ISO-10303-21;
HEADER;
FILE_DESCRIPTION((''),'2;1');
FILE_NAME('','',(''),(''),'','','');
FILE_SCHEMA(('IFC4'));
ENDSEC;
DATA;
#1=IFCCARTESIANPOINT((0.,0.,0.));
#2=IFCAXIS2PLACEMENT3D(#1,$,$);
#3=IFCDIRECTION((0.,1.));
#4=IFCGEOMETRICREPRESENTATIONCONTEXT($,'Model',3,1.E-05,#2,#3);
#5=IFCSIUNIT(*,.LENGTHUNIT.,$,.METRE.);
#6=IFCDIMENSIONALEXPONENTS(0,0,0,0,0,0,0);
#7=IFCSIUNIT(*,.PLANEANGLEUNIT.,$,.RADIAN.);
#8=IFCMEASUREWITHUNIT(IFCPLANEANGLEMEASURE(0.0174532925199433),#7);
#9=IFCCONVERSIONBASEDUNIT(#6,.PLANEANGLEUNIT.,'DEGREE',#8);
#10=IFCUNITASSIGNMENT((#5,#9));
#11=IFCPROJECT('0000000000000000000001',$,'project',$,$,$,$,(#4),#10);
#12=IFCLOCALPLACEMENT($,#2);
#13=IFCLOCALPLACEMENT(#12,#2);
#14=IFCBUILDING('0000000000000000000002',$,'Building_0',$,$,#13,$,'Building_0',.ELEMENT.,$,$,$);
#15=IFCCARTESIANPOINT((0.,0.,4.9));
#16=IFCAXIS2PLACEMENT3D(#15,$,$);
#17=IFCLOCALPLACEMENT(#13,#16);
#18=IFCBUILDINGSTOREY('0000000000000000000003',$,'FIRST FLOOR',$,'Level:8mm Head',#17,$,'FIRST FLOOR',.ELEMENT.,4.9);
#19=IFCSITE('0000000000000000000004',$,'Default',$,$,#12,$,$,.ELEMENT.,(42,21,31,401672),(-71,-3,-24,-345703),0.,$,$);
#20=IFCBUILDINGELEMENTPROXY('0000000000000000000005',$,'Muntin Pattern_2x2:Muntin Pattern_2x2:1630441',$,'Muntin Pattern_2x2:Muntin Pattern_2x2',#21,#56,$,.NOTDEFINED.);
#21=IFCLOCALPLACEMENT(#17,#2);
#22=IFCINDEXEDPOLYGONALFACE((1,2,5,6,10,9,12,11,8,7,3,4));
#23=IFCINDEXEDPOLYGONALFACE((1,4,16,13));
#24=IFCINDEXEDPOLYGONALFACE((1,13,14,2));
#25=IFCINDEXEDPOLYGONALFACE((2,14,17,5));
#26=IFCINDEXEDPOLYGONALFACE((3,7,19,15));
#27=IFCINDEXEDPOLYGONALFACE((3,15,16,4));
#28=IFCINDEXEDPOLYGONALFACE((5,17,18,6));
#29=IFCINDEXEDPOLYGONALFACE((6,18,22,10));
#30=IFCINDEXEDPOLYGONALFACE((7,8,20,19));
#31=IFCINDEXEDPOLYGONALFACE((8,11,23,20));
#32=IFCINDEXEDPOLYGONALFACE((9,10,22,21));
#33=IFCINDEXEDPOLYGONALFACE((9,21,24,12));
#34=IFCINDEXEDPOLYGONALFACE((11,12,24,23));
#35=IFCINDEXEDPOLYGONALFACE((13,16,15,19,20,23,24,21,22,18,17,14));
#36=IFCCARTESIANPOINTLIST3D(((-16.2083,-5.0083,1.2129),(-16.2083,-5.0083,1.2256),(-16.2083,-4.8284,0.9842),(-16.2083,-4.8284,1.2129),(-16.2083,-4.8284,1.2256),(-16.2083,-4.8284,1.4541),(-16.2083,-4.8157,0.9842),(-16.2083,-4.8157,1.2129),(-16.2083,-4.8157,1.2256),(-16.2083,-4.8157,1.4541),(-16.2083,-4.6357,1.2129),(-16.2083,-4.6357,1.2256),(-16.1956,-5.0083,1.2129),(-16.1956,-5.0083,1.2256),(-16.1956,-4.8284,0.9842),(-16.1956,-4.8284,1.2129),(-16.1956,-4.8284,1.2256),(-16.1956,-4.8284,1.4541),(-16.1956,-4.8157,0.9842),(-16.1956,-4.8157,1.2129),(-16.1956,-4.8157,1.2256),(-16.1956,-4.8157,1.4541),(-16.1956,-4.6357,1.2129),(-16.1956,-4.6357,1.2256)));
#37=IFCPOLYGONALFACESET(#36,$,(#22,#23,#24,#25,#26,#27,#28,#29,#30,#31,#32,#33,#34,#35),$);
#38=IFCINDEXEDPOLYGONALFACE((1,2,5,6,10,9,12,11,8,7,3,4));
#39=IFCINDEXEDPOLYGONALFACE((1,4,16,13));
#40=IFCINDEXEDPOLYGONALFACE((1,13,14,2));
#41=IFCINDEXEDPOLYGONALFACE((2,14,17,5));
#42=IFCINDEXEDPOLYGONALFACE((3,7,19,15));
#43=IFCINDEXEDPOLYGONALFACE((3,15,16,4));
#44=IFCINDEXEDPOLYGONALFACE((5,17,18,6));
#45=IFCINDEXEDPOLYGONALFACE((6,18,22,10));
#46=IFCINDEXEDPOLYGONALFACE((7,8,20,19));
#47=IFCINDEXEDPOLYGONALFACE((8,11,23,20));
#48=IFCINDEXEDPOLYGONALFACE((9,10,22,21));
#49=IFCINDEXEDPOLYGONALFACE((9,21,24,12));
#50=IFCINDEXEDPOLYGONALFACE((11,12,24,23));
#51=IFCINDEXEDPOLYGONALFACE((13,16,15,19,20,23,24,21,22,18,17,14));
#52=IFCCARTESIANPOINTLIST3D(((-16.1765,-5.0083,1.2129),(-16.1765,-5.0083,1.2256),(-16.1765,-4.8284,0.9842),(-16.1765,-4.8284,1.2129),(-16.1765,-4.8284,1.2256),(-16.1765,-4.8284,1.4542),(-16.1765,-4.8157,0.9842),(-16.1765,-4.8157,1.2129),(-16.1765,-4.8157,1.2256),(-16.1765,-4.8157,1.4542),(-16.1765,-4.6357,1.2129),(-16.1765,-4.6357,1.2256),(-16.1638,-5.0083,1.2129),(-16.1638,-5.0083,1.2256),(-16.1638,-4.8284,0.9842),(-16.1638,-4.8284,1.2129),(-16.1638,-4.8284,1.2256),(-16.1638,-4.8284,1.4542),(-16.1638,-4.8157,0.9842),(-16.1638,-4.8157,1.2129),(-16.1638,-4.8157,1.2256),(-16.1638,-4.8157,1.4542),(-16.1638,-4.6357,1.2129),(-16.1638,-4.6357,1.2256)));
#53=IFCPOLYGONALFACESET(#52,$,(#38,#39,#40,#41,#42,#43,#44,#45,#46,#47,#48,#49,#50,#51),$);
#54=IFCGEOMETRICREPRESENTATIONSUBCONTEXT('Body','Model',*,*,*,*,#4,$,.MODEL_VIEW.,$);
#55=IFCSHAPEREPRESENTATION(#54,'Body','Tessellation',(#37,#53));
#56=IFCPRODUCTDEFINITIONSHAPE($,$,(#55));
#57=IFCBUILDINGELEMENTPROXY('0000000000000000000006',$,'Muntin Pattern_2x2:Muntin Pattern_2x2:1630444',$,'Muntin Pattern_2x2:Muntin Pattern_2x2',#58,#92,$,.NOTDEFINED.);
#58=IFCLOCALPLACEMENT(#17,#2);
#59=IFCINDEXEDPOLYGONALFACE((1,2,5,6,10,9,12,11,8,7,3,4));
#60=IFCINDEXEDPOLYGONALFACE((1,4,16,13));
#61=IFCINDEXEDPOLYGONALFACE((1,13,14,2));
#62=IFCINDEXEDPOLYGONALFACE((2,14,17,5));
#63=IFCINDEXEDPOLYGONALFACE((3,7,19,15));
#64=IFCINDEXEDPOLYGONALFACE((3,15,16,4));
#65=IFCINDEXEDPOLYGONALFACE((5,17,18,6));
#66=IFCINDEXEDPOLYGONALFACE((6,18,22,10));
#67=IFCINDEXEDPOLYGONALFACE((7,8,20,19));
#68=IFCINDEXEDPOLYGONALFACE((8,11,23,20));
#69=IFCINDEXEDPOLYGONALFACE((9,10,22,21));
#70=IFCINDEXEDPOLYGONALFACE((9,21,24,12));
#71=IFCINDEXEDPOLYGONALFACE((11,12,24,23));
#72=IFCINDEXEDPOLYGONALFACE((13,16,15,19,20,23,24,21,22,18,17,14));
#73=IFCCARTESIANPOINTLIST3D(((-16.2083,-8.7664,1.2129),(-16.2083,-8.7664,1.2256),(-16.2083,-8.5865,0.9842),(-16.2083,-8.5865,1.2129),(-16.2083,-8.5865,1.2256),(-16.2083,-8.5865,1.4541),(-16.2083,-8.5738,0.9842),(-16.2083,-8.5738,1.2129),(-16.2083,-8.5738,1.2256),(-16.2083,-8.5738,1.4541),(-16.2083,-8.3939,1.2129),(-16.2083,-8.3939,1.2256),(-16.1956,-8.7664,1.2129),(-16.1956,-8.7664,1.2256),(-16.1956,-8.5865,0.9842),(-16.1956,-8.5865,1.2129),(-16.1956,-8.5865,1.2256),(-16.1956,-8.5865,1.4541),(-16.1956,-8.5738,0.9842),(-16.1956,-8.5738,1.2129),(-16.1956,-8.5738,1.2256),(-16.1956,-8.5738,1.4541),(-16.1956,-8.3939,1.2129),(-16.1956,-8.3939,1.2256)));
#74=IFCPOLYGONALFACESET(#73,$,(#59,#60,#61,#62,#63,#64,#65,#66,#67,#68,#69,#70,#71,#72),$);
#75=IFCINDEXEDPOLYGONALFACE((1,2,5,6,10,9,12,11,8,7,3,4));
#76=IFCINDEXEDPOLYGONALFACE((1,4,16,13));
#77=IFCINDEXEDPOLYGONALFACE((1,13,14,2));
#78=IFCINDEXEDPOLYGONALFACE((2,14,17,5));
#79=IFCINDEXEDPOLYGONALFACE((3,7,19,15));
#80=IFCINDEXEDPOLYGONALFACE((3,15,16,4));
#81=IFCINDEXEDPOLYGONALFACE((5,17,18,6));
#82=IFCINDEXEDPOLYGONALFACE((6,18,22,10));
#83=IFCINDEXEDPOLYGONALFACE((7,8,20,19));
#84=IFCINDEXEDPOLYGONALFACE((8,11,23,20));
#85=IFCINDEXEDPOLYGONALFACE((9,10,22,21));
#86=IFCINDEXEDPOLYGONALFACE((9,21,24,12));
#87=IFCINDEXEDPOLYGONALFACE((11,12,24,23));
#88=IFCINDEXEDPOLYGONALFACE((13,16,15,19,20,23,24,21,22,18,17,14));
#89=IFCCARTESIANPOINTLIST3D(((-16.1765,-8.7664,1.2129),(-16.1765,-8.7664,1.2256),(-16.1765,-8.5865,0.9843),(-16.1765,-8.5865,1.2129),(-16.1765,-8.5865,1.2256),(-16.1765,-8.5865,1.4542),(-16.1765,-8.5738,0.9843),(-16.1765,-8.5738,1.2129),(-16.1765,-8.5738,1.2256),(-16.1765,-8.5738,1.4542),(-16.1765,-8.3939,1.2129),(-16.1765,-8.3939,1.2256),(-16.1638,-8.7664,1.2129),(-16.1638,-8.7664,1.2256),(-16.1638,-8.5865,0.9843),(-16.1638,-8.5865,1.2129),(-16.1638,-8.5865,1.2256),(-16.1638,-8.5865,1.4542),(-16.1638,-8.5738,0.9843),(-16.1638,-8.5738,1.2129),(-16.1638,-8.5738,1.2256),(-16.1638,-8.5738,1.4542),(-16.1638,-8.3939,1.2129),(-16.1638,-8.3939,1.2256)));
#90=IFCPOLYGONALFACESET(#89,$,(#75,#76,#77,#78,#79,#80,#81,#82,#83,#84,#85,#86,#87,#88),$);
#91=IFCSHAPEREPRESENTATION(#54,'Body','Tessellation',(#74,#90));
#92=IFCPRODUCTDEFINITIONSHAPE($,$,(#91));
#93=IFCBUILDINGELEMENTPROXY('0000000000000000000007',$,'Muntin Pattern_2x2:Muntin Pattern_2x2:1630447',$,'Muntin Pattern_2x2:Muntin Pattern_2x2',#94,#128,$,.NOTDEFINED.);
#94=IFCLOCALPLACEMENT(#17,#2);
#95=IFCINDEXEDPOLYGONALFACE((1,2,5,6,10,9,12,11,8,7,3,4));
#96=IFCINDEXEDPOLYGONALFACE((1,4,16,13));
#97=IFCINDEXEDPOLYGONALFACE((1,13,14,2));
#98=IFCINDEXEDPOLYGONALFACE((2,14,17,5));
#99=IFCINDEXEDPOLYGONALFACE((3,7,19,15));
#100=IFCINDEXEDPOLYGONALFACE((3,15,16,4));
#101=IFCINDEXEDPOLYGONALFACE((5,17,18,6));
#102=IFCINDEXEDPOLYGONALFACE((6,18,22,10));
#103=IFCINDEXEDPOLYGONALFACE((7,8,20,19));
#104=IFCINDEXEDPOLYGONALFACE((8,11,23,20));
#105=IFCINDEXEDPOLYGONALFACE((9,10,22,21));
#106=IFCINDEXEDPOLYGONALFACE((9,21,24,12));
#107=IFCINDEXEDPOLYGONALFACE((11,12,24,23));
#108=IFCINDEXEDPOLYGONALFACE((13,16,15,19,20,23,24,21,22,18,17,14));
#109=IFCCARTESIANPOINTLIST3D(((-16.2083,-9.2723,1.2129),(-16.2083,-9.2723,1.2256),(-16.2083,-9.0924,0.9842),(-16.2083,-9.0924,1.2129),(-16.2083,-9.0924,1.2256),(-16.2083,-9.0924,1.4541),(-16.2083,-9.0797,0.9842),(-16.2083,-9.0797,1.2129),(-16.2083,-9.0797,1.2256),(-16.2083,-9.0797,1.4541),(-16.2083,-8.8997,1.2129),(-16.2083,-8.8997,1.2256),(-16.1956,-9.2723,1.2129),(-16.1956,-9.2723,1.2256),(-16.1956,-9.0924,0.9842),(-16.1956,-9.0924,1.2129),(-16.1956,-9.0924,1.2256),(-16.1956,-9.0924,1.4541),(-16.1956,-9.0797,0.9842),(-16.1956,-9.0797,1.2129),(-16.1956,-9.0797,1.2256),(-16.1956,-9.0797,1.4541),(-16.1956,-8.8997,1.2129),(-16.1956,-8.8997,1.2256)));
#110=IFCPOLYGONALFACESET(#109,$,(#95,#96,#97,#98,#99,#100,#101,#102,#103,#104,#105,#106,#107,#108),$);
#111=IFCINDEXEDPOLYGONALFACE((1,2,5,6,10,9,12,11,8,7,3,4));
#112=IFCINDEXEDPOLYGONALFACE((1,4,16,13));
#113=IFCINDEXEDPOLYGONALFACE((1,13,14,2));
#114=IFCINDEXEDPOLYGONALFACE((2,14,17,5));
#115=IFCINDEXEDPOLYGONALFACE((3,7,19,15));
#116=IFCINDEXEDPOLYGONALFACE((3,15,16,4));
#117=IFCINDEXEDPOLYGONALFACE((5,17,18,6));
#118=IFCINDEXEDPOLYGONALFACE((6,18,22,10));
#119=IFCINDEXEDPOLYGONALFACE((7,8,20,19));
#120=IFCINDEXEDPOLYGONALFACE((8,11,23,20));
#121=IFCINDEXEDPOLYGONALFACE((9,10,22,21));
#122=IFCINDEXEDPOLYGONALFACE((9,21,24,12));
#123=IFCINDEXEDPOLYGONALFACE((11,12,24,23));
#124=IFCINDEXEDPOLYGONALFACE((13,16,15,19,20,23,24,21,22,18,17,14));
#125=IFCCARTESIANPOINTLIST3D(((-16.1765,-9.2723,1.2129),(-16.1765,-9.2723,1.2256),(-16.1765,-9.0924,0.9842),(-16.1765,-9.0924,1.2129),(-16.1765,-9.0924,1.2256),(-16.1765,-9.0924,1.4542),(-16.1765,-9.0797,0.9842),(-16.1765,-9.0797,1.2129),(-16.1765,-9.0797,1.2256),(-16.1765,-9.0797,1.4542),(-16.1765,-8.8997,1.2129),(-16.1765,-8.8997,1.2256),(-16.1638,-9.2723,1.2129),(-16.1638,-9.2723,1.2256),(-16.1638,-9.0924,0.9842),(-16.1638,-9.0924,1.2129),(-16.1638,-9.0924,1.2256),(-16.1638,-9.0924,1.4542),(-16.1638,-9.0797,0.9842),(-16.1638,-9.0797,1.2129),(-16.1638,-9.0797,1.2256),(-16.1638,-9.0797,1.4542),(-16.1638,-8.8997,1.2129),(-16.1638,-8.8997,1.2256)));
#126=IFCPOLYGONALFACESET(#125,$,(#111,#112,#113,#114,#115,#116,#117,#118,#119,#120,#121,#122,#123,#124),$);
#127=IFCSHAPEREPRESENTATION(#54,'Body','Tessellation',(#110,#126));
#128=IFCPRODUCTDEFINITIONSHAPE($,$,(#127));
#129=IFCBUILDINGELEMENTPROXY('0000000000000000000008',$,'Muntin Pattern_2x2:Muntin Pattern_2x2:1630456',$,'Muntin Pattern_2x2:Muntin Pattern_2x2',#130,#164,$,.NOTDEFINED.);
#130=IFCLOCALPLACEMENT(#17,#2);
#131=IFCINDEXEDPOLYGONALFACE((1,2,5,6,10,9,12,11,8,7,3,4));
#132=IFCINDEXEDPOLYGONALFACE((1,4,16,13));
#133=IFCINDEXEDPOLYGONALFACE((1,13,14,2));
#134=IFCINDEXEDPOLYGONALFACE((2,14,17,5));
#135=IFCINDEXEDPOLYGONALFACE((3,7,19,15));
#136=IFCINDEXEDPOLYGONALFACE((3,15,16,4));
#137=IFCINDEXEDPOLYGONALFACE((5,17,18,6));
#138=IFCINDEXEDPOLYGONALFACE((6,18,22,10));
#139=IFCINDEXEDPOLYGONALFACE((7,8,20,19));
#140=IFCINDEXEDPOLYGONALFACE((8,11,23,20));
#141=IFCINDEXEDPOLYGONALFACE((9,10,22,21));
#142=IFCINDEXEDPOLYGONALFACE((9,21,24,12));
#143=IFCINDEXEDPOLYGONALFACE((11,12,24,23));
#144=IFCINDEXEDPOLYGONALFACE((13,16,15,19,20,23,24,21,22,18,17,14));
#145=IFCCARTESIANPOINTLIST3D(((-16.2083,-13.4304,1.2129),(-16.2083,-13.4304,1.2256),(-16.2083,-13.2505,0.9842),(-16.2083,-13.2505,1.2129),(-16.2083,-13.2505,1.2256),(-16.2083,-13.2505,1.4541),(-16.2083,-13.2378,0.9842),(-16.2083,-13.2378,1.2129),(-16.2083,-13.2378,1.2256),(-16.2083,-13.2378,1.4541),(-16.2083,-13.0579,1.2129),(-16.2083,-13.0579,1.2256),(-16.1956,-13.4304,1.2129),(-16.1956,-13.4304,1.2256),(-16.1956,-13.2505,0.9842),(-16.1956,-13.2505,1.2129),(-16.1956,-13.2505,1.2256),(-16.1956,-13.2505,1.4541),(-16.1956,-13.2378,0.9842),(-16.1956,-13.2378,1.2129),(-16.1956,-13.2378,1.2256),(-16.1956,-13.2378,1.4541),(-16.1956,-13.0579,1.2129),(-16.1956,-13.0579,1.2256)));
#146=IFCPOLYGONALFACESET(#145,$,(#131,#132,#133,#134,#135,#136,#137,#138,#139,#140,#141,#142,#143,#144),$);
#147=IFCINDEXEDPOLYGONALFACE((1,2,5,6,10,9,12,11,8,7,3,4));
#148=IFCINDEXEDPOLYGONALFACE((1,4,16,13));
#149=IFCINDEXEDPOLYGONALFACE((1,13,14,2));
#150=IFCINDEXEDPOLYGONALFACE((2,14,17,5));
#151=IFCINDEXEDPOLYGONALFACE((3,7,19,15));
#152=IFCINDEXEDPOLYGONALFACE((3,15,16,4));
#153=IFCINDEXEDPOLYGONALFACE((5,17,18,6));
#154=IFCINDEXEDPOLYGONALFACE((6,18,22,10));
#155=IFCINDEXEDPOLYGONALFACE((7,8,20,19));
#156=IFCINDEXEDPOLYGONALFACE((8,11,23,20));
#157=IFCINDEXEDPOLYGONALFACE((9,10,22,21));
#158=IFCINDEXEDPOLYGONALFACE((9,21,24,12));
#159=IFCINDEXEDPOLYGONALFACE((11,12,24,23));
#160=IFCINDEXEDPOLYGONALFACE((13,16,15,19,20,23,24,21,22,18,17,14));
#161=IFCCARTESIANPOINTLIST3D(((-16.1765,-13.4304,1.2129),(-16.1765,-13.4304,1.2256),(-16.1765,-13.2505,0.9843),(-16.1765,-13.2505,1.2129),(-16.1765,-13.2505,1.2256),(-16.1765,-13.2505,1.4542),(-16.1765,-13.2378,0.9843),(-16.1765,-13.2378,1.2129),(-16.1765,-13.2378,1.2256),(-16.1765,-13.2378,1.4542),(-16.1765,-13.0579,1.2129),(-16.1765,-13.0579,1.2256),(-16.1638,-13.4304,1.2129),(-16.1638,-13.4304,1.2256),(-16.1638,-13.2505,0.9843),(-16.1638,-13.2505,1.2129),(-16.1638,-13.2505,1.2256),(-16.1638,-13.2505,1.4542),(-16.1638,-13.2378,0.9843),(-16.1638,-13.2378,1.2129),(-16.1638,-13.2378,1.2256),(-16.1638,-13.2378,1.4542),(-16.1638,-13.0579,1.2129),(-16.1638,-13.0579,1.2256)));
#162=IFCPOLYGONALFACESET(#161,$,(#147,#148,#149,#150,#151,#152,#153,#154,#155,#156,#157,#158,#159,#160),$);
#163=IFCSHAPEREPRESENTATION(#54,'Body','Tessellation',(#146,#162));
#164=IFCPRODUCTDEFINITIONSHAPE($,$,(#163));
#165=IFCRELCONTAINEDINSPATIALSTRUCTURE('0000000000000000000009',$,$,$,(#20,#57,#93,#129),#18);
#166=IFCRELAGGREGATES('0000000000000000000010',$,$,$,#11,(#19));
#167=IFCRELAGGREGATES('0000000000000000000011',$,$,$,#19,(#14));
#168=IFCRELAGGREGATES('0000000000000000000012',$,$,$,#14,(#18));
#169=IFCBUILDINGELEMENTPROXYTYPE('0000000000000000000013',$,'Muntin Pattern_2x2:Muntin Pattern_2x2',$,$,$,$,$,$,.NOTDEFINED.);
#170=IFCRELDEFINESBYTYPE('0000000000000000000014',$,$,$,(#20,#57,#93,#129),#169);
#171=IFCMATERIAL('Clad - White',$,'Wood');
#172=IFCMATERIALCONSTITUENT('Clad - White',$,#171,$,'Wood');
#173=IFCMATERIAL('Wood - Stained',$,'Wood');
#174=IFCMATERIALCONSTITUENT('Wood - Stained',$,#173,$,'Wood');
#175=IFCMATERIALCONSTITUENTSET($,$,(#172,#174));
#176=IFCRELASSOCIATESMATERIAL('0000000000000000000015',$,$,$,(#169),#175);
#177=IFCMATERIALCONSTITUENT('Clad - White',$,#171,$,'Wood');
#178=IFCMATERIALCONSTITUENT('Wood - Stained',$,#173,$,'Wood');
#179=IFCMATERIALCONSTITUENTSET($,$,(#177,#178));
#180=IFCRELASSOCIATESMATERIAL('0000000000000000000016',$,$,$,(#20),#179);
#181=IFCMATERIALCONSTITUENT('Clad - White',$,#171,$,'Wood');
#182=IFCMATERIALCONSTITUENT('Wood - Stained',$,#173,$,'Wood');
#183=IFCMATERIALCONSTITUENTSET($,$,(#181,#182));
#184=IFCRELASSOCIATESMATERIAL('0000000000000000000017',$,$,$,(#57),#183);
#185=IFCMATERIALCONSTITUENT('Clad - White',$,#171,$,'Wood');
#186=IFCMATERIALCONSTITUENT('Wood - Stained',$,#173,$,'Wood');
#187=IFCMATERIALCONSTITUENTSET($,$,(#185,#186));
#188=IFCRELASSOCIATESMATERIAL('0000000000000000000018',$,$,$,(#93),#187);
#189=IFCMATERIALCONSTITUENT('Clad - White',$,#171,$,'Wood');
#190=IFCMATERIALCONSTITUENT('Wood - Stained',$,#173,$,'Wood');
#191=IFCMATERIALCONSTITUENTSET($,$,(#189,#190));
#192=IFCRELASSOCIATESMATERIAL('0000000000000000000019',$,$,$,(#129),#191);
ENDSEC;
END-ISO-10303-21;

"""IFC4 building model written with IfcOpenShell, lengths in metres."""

from ifc_helpers import new_model, entity, si_unit, converted_unit, direction, frame, origin, place, context, subcontext, project, spatial, indexed_curve, outline, extrude, source, transform, mapped, material, constituent, constituent_set, type_object, type_shapes, element, save


model = new_model("IFC4")

# Units and contexts
model_context = context("Model", 3, precision=1e-05, world=origin(), true_north=direction((0.0, 1.0)))
body_context = subcontext(model_context, "Body", "Model", "MODEL_VIEW")
ifc_project = project(units=[si_unit("LENGTHUNIT", "METRE"), converted_unit("PLANEANGLEUNIT", "DEGREE", entity("IfcPlaneAngleMeasure", 0.0174532925199433), si_unit("PLANEANGLEUNIT", "RADIAN"), dimensions=[0, 0, 0, 0, 0, 0, 0])], contexts=[model_context])

# Site, building, storey
site_placement = place(None, origin())
site = spatial("IfcSite", under=ifc_project, at=site_placement, Name="Default", CompositionType="ELEMENT", RefLatitude=(42, 21, 31, 401672), RefLongitude=(-71, -3, -24, -345703), RefElevation=0.0)
building_placement = place(site_placement, origin())
building = spatial("IfcBuilding", under=site, at=building_placement, Name="Building_0", LongName="Building_0", CompositionType="ELEMENT")
storey_placement = place(building_placement, frame((0.0, 0.0, 4.9)))
storey = spatial("IfcBuildingStorey", under=building, at=storey_placement, Name="FIRST FLOOR", ObjectType="Level:8mm Head", LongName="FIRST FLOOR", CompositionType="ELEMENT", Elevation=4.9)

# Shared definitions
ifc_material_1 = material(Name="Clad - White", Category="Wood")

# Building element proxies
ifc_material_2 = material(Name="Wood - Stained", Category="Wood")
ifc_constituent_1 = constituent(ifc_material_1, Name="Clad - White", Category="Wood")
ifc_constituent_2 = constituent(ifc_material_2, Name="Wood - Stained", Category="Wood")
ifc_constituent_set_1 = constituent_set(constituents=[ifc_constituent_1, ifc_constituent_2])
building_element_proxy_type_1 = type_object("IfcBuildingElementProxyType", Name="Muntin Pattern_2x2:Muntin Pattern_2x2", PredefinedType="NOTDEFINED", material=ifc_constituent_set_1)
shared_shape_1 = source(origin(), body_context, "Body", "SweptSolid", [
    extrude(outline(indexed_curve([(0.0064, -0.0064), (0.2349, -0.0064), (0.2349, 0.0063), (0.0064, 0.0063), (0.0064, 0.1863), (-0.0063, 0.1863), (-0.0063, 0.0063), (-0.235, 0.0063), (-0.235, -0.0064), (-0.0063, -0.0064), (-0.0063, -0.1863), (0.0064, -0.1863), (0.0064, -0.0064)], self_intersect=False)), frame((0.0, -0.0222, 0.2349), z_axis=(0.0, 1.0, 0.0), x_axis=(0.0, 0.0, 1.0)), (0.0, 0.0, 1.0), 0.0127),
    extrude(outline(indexed_curve([(0.0064, -0.0064), (0.235, -0.0064), (0.235, 0.0063), (0.0064, 0.0063), (0.0064, 0.1863), (-0.0063, 0.1863), (-0.0063, 0.0063), (-0.235, 0.0063), (-0.235, -0.0064), (-0.0063, -0.0064), (-0.0063, -0.1863), (0.0064, -0.1863), (0.0064, -0.0064)], self_intersect=False)), frame((0.0, 0.0095, 0.235), z_axis=(0.0, 1.0, 0.0), x_axis=(0.0, 0.0, 1.0)), (0.0, 0.0, 1.0), 0.0127),
])
type_shapes(building_element_proxy_type_1, [shared_shape_1])
ifc_constituent_3 = constituent(ifc_material_1, Name="Clad - White", Category="Wood")
ifc_constituent_4 = constituent(ifc_material_2, Name="Wood - Stained", Category="Wood")
ifc_constituent_set_2 = constituent_set(constituents=[ifc_constituent_3, ifc_constituent_4])
proxy_1_placement = place(storey_placement, frame((-16.1861, -4.822, 0.9842), z_axis=(0.0, 0.0, 1.0), x_axis=(0.0, -1.0, 0.0)))
element("IfcBuildingElementProxy", 1, at=proxy_1_placement, inside=storey, type_object=building_element_proxy_type_1, material=ifc_constituent_set_2, Name="Muntin Pattern_2x2:Muntin Pattern_2x2:1630441", ObjectType="Muntin Pattern_2x2:Muntin Pattern_2x2", PredefinedType="NOTDEFINED", context=body_context, shape_type="MappedRepresentation", body=[
    mapped(shared_shape_1, transform((0.0, 0.0, 0.0), scale=1.0)),
])
ifc_constituent_5 = constituent(ifc_material_1, Name="Clad - White", Category="Wood")
ifc_constituent_6 = constituent(ifc_material_2, Name="Wood - Stained", Category="Wood")
ifc_constituent_set_3 = constituent_set(constituents=[ifc_constituent_5, ifc_constituent_6])
proxy_2_placement = place(storey_placement, frame((-16.1861, -8.5801, 0.9843), z_axis=(0.0, 0.0, 1.0), x_axis=(0.0, -1.0, 0.0)))
element("IfcBuildingElementProxy", 2, at=proxy_2_placement, inside=storey, type_object=building_element_proxy_type_1, material=ifc_constituent_set_3, Name="Muntin Pattern_2x2:Muntin Pattern_2x2:1630444", ObjectType="Muntin Pattern_2x2:Muntin Pattern_2x2", PredefinedType="NOTDEFINED", context=body_context, shape_type="MappedRepresentation", body=[
    mapped(shared_shape_1, transform((0.0, 0.0, 0.0), scale=1.0)),
])
ifc_constituent_7 = constituent(ifc_material_1, Name="Clad - White", Category="Wood")
ifc_constituent_8 = constituent(ifc_material_2, Name="Wood - Stained", Category="Wood")
ifc_constituent_set_4 = constituent_set(constituents=[ifc_constituent_7, ifc_constituent_8])
proxy_3_placement = place(storey_placement, frame((-16.1861, -9.086, 0.9842), z_axis=(0.0, 0.0, 1.0), x_axis=(0.0, -1.0, 0.0)))
element("IfcBuildingElementProxy", 3, at=proxy_3_placement, inside=storey, type_object=building_element_proxy_type_1, material=ifc_constituent_set_4, Name="Muntin Pattern_2x2:Muntin Pattern_2x2:1630447", ObjectType="Muntin Pattern_2x2:Muntin Pattern_2x2", PredefinedType="NOTDEFINED", context=body_context, shape_type="MappedRepresentation", body=[
    mapped(shared_shape_1, transform((0.0, 0.0, 0.0), scale=1.0)),
])
ifc_constituent_9 = constituent(ifc_material_1, Name="Clad - White", Category="Wood")
ifc_constituent_10 = constituent(ifc_material_2, Name="Wood - Stained", Category="Wood")
ifc_constituent_set_5 = constituent_set(constituents=[ifc_constituent_9, ifc_constituent_10])
proxy_4_placement = place(storey_placement, frame((-16.1861, -13.2441, 0.9843), z_axis=(0.0, 0.0, 1.0), x_axis=(0.0, -1.0, 0.0)))
element("IfcBuildingElementProxy", 4, at=proxy_4_placement, inside=storey, type_object=building_element_proxy_type_1, material=ifc_constituent_set_5, Name="Muntin Pattern_2x2:Muntin Pattern_2x2:1630456", ObjectType="Muntin Pattern_2x2:Muntin Pattern_2x2", PredefinedType="NOTDEFINED", context=body_context, shape_type="MappedRepresentation", body=[
    mapped(shared_shape_1, transform((0.0, 0.0, 0.0), scale=1.0)),
])

save(model, "model.ifc")
